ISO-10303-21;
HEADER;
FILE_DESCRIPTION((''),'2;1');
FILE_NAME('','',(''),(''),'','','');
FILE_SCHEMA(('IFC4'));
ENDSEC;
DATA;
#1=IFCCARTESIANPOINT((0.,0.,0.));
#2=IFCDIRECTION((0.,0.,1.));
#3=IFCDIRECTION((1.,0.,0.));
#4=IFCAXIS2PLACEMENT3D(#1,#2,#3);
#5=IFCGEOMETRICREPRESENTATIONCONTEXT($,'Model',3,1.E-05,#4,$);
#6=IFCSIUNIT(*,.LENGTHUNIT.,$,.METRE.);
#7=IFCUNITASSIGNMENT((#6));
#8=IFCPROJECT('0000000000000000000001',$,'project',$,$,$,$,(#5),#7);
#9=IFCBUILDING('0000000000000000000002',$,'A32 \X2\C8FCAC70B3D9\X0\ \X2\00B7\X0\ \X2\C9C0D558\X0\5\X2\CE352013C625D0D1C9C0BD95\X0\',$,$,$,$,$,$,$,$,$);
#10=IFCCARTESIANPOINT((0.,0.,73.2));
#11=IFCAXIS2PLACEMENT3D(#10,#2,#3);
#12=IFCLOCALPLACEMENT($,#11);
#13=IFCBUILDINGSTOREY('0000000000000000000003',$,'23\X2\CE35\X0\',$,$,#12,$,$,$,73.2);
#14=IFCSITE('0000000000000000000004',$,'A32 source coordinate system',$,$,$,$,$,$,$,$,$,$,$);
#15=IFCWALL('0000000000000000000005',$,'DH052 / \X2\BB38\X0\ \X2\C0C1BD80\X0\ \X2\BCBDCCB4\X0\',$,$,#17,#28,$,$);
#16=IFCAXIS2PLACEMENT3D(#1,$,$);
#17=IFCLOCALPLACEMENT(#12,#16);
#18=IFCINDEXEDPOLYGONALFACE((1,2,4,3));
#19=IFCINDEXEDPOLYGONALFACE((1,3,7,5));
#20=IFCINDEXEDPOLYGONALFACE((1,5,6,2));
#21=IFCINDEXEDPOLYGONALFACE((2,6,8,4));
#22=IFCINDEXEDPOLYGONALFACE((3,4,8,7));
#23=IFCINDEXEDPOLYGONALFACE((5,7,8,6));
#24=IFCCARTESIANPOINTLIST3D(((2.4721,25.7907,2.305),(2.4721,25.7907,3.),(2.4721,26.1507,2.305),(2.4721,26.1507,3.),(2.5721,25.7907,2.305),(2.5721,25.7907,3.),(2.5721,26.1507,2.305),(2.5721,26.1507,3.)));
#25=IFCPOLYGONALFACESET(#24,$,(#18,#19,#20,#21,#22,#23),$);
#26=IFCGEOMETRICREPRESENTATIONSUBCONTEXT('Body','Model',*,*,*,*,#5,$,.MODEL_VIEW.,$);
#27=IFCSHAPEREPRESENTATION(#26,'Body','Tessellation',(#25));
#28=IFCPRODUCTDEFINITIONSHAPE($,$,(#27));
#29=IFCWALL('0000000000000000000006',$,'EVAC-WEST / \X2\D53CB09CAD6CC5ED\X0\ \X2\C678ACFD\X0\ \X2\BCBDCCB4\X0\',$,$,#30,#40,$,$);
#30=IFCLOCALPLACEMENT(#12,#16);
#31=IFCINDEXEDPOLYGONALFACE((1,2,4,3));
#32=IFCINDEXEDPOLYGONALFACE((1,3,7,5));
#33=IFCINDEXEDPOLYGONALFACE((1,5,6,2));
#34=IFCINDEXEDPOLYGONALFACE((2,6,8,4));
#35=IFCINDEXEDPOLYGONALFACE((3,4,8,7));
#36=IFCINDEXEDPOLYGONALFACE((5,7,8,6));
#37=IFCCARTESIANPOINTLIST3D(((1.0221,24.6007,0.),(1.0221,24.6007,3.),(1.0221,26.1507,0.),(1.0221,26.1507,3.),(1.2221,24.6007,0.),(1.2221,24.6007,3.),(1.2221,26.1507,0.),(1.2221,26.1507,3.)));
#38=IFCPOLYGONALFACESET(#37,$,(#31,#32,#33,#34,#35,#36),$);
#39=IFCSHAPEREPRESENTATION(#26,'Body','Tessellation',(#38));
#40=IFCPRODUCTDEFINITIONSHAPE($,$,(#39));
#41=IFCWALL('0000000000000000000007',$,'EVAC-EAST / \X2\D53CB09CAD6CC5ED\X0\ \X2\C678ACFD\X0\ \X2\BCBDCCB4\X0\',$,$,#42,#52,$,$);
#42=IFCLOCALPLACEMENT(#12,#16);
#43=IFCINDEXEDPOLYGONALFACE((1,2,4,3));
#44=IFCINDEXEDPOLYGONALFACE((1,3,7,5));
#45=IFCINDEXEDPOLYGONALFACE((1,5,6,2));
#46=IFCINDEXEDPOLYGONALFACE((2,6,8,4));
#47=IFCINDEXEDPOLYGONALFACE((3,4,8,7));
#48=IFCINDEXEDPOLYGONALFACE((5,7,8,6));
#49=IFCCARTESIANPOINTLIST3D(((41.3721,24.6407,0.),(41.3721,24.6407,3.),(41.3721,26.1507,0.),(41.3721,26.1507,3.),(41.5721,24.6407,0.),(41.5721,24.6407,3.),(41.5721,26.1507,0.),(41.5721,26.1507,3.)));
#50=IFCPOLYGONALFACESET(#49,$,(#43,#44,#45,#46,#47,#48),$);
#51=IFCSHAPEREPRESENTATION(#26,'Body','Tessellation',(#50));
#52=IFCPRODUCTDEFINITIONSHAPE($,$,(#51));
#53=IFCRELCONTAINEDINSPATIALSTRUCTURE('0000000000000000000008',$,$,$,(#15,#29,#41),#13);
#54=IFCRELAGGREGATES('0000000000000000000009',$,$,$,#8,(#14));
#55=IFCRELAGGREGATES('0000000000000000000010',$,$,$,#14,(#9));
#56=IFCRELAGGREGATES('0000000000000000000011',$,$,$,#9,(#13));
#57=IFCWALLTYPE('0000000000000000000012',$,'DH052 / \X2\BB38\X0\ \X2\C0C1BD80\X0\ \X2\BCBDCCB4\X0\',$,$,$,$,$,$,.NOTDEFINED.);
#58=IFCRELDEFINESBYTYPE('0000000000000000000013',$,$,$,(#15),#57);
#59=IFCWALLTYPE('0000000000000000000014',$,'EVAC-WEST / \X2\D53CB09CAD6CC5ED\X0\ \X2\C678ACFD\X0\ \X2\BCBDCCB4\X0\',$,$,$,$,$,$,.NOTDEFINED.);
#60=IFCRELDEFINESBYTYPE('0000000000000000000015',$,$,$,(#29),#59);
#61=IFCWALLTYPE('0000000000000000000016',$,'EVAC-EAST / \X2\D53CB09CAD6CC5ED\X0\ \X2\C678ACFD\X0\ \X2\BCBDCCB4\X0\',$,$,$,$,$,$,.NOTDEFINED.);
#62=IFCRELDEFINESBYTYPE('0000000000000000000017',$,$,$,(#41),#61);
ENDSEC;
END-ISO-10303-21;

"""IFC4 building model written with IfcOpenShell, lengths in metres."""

from ifc_helpers import new_model, si_unit, frame, origin, origin_with_axes, place, context, subcontext, project, spatial, polyline, outline, extrude, source, transform, mapped, type_object, type_shapes, element, save


model = new_model("IFC4")

# Units and contexts
model_context = context("Model", 3, precision=1e-05, world=origin_with_axes())
body_context = subcontext(model_context, "Body", "Model", "MODEL_VIEW")
ifc_project = project(units=[si_unit("LENGTHUNIT", "METRE")], contexts=[model_context])

# Site, building, storey
site = spatial("IfcSite", under=ifc_project, Name="A32 source coordinate system")
building = spatial("IfcBuilding", under=site, Name="A32 주거동 · 지하5층–옥탑지붕")
storey_placement = place(None, frame((0.0, 0.0, 73.2), z_axis=(0.0, 0.0, 1.0), x_axis=(1.0, 0.0, 0.0)))
storey = spatial("IfcBuildingStorey", under=building, at=storey_placement, Name="23층", Elevation=73.2)

# Walls
wall_type_1 = type_object("IfcWallType", Name="DH052 / 문 상부 벽체", PredefinedType="NOTDEFINED")
shared_shape_1 = source(origin(), body_context, "Body", "SweptSolid", [
    extrude(outline(polyline([(2.5721, 25.7907), (2.4721, 25.7907), (2.4721, 26.1507), (2.5721, 26.1507), (2.5721, 25.7907)])), frame((0.0, 0.0, 2.305)), (0.0, 0.0, 1.0), 0.695),
])
type_shapes(wall_type_1, [shared_shape_1])
wall_1_placement = place(storey_placement, origin_with_axes())
element("IfcWall", 1, at=wall_1_placement, inside=storey, type_object=wall_type_1, Name="DH052 / 문 상부 벽체", context=body_context, shape_type="MappedRepresentation", body=[
    mapped(shared_shape_1, transform((0.0, 0.0, 0.0), scale=1.0)),
])
wall_type_2 = type_object("IfcWallType", Name="EVAC-WEST / 피난구역 외곽 벽체", PredefinedType="NOTDEFINED")
shared_shape_2 = source(origin(), body_context, "Body", "SweptSolid", [
    extrude(outline(polyline([(1.2221, 24.6007), (1.0221, 24.6007), (1.0221, 26.1507), (1.2221, 26.1507), (1.2221, 24.6007)])), origin(), (0.0, 0.0, 1.0), 3.0),
])
type_shapes(wall_type_2, [shared_shape_2])
wall_2_placement = place(storey_placement, origin_with_axes())
element("IfcWall", 2, at=wall_2_placement, inside=storey, type_object=wall_type_2, Name="EVAC-WEST / 피난구역 외곽 벽체", context=body_context, shape_type="MappedRepresentation", body=[
    mapped(shared_shape_2, transform((0.0, 0.0, 0.0), scale=1.0)),
])
wall_type_3 = type_object("IfcWallType", Name="EVAC-EAST / 피난구역 외곽 벽체", PredefinedType="NOTDEFINED")
shared_shape_3 = source(origin(), body_context, "Body", "SweptSolid", [
    extrude(outline(polyline([(41.5721, 26.1507), (41.5721, 24.6407), (41.3721, 24.6407), (41.3721, 26.1507), (41.5721, 26.1507)])), origin(), (0.0, 0.0, 1.0), 3.0),
])
type_shapes(wall_type_3, [shared_shape_3])
wall_3_placement = place(storey_placement, origin_with_axes())
element("IfcWall", 3, at=wall_3_placement, inside=storey, type_object=wall_type_3, Name="EVAC-EAST / 피난구역 외곽 벽체", context=body_context, shape_type="MappedRepresentation", body=[
    mapped(shared_shape_3, transform((0.0, 0.0, 0.0), scale=1.0)),
])

save(model, "model.ifc")
